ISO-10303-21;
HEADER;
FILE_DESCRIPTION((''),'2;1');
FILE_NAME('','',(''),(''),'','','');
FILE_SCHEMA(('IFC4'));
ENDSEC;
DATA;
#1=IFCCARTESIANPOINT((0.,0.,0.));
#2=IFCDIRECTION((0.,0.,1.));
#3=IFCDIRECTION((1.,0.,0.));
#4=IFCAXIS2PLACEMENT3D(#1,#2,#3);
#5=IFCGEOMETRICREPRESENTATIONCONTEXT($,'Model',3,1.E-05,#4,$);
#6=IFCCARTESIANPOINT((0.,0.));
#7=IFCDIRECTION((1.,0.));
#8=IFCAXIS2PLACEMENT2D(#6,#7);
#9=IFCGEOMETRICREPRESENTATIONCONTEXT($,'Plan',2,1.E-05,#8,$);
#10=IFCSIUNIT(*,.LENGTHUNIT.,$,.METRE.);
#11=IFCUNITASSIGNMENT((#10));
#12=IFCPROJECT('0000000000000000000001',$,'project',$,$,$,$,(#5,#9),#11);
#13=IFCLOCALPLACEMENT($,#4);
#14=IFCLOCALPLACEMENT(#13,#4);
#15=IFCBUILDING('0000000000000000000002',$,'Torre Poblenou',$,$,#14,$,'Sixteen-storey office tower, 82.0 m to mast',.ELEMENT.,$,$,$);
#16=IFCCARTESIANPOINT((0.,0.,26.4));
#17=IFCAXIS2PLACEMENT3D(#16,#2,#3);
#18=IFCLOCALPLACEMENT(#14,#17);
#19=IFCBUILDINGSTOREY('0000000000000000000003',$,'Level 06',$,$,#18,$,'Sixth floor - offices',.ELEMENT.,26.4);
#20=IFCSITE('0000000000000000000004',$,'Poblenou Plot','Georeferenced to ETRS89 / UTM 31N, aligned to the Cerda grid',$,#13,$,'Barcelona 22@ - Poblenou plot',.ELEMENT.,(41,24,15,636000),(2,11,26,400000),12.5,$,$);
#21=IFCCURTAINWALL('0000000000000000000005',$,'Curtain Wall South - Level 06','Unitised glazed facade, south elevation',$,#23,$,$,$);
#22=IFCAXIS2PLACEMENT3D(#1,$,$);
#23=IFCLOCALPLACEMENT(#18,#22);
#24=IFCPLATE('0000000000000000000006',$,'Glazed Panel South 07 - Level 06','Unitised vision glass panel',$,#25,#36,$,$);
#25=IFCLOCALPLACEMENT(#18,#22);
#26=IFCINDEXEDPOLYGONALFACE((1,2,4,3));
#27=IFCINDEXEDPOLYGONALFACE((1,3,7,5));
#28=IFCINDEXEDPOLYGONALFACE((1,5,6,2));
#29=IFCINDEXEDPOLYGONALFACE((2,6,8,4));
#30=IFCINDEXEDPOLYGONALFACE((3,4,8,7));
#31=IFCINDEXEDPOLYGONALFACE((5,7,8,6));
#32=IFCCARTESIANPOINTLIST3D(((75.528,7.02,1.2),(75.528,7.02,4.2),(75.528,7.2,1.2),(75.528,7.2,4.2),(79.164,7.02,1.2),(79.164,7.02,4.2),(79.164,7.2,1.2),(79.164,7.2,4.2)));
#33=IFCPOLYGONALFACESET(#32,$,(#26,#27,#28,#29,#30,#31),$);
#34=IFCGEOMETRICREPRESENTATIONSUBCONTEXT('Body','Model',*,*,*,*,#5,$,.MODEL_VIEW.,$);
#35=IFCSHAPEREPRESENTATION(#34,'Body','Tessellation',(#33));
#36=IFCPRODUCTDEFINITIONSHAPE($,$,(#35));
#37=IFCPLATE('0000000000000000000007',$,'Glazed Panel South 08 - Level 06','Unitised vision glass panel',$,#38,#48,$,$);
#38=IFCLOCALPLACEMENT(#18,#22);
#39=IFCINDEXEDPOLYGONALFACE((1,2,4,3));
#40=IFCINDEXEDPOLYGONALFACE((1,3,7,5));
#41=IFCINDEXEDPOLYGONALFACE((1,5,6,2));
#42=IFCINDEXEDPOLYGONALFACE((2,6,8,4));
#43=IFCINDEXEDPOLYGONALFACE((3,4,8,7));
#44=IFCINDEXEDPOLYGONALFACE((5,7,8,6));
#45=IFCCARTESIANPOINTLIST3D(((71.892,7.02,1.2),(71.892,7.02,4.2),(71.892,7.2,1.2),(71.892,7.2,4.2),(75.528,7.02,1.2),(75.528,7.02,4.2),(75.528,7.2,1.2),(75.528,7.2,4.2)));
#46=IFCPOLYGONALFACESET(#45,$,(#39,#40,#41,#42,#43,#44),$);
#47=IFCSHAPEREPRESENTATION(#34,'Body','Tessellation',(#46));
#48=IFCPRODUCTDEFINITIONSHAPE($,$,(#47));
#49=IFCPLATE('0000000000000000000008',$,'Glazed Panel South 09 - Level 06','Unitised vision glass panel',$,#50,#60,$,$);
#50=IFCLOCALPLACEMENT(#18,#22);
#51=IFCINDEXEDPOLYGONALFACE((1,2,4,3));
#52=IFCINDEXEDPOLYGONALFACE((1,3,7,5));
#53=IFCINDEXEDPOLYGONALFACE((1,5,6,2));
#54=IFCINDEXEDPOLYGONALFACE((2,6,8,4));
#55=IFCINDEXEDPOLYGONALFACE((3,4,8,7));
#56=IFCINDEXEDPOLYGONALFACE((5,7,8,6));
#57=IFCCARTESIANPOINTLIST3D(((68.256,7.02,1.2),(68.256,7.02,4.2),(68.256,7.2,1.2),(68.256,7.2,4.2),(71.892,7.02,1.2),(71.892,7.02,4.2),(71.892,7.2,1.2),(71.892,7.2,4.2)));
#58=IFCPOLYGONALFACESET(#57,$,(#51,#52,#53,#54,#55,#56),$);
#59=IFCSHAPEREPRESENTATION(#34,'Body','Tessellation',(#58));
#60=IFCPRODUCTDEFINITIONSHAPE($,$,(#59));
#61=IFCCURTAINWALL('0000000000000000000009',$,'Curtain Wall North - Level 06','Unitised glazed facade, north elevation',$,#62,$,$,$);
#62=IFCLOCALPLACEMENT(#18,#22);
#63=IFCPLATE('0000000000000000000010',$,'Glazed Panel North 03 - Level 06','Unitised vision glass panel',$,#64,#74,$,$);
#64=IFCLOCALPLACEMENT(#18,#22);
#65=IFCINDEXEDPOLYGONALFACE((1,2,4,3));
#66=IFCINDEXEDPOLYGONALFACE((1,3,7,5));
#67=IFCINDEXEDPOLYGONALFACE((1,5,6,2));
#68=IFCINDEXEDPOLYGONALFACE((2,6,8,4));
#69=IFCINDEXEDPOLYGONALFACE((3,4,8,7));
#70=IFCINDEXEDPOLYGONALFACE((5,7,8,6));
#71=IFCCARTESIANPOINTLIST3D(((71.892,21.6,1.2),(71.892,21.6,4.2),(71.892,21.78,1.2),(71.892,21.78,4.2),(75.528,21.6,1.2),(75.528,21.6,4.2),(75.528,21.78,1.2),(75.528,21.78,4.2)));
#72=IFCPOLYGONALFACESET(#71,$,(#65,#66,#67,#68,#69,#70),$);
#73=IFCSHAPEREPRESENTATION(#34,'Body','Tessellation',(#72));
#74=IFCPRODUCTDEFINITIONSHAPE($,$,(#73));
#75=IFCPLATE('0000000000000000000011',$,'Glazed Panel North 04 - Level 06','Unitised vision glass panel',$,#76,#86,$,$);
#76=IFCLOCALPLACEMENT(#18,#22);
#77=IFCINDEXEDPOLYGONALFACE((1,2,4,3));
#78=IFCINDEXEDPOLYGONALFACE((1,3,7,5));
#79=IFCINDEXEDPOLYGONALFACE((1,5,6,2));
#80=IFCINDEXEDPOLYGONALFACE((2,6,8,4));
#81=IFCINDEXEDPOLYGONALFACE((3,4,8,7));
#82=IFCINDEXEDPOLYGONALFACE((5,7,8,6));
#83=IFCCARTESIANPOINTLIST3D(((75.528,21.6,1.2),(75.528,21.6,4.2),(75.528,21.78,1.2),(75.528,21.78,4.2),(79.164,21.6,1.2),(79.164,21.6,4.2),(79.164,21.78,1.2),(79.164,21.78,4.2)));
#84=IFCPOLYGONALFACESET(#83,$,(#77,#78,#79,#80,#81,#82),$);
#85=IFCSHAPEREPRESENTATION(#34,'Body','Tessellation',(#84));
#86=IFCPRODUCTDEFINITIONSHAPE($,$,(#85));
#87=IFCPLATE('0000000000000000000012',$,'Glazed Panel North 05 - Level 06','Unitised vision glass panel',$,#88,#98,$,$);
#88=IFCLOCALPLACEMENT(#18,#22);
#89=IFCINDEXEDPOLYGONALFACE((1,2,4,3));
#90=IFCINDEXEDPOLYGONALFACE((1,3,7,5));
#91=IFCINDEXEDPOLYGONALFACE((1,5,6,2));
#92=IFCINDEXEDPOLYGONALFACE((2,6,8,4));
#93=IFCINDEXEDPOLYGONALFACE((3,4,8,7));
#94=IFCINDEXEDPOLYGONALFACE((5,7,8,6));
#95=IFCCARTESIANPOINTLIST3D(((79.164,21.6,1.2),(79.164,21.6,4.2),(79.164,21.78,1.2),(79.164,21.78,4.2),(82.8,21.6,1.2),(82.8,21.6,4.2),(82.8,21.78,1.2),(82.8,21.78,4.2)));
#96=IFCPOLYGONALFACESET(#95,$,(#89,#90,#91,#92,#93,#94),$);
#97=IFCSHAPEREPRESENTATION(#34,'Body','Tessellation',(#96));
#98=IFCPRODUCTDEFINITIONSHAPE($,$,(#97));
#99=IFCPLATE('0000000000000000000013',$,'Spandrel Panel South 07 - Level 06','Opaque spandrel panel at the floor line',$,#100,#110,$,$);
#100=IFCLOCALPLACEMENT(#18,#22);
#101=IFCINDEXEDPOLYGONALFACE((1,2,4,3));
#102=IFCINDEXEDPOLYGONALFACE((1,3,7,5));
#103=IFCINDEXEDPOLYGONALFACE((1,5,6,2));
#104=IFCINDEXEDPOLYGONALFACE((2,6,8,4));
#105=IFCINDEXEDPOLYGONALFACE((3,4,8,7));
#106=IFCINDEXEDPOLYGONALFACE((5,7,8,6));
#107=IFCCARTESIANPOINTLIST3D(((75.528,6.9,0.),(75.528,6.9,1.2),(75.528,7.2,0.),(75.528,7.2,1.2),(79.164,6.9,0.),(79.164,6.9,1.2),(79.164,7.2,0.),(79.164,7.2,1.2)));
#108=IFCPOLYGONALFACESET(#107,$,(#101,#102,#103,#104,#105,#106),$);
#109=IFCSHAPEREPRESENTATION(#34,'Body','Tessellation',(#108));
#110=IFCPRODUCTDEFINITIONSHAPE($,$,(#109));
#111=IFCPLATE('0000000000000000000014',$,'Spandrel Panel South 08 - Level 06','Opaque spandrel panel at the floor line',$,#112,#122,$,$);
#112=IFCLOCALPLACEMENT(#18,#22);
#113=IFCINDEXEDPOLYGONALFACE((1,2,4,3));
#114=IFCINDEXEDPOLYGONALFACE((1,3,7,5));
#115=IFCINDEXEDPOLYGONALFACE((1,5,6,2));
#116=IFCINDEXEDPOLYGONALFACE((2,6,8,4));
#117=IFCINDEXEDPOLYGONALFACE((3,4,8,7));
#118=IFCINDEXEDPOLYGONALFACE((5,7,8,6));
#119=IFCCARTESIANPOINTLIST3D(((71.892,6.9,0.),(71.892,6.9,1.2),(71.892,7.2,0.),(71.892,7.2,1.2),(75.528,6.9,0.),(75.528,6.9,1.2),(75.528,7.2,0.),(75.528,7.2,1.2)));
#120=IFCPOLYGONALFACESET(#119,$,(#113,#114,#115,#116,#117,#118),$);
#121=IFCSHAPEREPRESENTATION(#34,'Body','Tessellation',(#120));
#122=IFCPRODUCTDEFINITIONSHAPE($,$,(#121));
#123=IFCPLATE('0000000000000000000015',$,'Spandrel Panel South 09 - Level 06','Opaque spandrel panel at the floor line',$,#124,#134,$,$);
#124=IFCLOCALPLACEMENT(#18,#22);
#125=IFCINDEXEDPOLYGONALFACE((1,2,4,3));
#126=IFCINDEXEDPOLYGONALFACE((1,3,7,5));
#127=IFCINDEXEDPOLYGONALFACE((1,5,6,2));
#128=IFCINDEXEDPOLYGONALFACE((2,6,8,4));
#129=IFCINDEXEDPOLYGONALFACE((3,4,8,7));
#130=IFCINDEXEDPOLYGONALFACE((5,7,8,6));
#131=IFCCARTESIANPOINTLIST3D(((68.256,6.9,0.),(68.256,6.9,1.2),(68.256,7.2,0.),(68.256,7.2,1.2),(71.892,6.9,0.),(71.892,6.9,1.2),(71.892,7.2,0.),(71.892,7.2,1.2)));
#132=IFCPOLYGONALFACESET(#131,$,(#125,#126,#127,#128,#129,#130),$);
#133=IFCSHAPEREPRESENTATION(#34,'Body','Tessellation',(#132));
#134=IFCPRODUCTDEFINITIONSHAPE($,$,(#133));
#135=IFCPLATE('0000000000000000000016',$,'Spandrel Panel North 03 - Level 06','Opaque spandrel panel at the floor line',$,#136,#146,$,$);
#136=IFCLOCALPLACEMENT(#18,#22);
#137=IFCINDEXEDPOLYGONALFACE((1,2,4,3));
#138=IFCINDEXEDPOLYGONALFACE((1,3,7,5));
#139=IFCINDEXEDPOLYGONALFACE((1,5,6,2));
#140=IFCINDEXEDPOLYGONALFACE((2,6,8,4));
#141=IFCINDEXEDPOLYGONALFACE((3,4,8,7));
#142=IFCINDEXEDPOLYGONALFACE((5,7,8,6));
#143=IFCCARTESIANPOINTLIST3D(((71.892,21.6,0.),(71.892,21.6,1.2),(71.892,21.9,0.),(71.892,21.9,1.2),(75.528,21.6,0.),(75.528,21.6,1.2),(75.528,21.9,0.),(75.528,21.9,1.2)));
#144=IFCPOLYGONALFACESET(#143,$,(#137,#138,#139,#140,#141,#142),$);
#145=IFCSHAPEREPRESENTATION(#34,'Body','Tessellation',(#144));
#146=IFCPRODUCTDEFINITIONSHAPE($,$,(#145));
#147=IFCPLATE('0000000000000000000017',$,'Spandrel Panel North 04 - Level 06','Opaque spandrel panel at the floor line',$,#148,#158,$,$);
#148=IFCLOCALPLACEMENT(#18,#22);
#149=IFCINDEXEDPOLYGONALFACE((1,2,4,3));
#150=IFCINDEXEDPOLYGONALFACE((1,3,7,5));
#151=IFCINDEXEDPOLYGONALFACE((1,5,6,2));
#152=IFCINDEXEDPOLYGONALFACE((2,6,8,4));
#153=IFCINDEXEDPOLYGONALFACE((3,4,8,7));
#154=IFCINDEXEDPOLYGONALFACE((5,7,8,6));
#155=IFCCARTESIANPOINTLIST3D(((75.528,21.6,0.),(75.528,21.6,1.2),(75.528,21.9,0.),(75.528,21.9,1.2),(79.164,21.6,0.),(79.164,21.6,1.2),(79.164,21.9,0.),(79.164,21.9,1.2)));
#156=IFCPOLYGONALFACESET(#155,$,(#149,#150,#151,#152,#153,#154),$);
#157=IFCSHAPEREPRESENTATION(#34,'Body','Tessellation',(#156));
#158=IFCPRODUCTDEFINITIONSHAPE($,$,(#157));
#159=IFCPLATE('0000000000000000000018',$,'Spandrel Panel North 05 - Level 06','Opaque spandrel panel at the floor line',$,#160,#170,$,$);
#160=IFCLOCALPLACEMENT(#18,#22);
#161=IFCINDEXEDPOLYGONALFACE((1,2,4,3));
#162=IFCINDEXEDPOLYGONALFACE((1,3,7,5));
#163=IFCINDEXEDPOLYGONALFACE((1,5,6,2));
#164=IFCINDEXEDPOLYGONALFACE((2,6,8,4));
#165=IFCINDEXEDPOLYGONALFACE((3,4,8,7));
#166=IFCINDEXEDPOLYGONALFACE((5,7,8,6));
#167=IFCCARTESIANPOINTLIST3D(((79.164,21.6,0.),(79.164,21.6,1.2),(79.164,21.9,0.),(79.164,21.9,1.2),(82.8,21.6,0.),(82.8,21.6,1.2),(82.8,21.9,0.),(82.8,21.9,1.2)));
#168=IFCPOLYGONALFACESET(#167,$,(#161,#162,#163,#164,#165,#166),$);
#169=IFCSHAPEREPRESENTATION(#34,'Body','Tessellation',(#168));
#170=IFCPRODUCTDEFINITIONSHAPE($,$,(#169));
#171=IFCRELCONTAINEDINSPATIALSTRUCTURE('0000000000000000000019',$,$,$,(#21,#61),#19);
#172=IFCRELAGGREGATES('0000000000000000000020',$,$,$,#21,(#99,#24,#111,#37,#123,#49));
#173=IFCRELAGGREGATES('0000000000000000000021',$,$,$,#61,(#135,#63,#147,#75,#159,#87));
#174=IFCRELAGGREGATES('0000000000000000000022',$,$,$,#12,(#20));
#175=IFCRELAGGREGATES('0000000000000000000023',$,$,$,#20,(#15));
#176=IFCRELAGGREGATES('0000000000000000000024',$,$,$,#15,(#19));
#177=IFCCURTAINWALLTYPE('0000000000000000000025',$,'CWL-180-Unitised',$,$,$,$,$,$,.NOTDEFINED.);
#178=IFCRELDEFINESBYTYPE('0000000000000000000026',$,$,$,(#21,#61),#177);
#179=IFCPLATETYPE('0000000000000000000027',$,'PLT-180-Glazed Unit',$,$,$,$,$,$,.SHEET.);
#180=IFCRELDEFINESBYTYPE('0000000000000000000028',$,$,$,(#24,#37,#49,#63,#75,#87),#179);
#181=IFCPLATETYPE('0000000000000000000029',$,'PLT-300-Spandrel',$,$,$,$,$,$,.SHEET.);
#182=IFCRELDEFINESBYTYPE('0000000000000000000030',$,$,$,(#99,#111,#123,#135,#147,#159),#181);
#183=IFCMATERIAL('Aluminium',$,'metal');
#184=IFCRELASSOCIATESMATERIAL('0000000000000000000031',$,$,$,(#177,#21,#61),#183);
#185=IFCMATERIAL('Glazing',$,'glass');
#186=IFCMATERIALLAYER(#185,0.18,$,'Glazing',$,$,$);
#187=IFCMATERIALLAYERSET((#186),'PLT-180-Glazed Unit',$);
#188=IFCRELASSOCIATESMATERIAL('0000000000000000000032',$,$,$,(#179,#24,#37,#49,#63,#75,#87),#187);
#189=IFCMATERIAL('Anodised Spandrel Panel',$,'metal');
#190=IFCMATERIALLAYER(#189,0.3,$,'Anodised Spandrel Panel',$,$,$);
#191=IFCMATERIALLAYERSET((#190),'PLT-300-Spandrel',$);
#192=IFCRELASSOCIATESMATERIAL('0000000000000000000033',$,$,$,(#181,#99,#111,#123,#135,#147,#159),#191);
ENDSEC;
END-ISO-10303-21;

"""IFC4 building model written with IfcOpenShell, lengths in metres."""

from ifc_helpers import new_model, si_unit, frame, origin_with_axes, origin_2d_with_axis, place, context, subcontext, project, spatial, line, indexed_curve, outline, extrude, material, layer, layer_set, layer_usage, type_object, element, aggregate, save


model = new_model("IFC4")

# Units and contexts
model_context = context("Model", 3, precision=1e-05, world=origin_with_axes())
plan_context = context("Plan", 2, precision=1e-05, world=origin_2d_with_axis())
body_context = subcontext(model_context, "Body", "Model", "MODEL_VIEW")
ifc_project = project(units=[si_unit("LENGTHUNIT", "METRE")], contexts=[model_context, plan_context])

# Site, building, storey
site_placement = place(None, origin_with_axes())
site = spatial("IfcSite", under=ifc_project, at=site_placement, Name="Poblenou Plot", Description="Georeferenced to ETRS89 / UTM 31N, aligned to the Cerda grid", LongName="Barcelona 22@ - Poblenou plot", CompositionType="ELEMENT", RefLatitude=(41, 24, 15, 636000), RefLongitude=(2, 11, 26, 400000), RefElevation=12.5)
building_placement = place(site_placement, origin_with_axes())
building = spatial("IfcBuilding", under=site, at=building_placement, Name="Torre Poblenou", LongName="Sixteen-storey office tower, 82.0 m to mast", CompositionType="ELEMENT")
storey_placement = place(building_placement, frame((0.0, 0.0, 26.4), z_axis=(0.0, 0.0, 1.0), x_axis=(1.0, 0.0, 0.0)))
storey = spatial("IfcBuildingStorey", under=building, at=storey_placement, Name="Level 06", LongName="Sixth floor - offices", CompositionType="ELEMENT", Elevation=26.4)

# Curtain walls, plates
ifc_material_1 = material(Name="Aluminium", Category="metal")
curtain_wall_type = type_object("IfcCurtainWallType", Name="CWL-180-Unitised", PredefinedType="NOTDEFINED", material=ifc_material_1)
curtain_wall_1_placement = place(storey_placement, frame((100.98, 7.2, 0.0), z_axis=(0.0, 0.0, 1.0), x_axis=(-1.0, 0.0, 0.0)))
curtain_wall_1 = element("IfcCurtainWall", 1, at=curtain_wall_1_placement, inside=storey, type_object=curtain_wall_type, material=ifc_material_1, Name="Curtain Wall South - Level 06", Description="Unitised glazed facade, south elevation")
ifc_material_2 = material(Name="Glazing", Category="glass")
ifc_layer_1 = layer(ifc_material_2, 0.18, Name="Glazing")
ifc_layer_set_1 = layer_set([ifc_layer_1], Name="PLT-180-Glazed Unit")
ifc_layer_usage_1 = layer_usage(ifc_layer_set_1, "AXIS2", "POSITIVE", 0.0)
plate_type_1 = type_object("IfcPlateType", Name="PLT-180-Glazed Unit", PredefinedType="SHEET", material=ifc_layer_set_1)
plate_1_placement = place(curtain_wall_1_placement, frame((21.816, 0.0, 1.2), z_axis=(0.0, 0.0, 1.0), x_axis=(1.0, 0.0, 0.0)))
plate_1 = element("IfcPlate", 2, at=plate_1_placement, type_object=plate_type_1, material=ifc_layer_usage_1, Name="Glazed Panel South 07 - Level 06", Description="Unitised vision glass panel", context=body_context, shape_type="SweptSolid", body=[
    extrude(outline(indexed_curve([(0.0, 0.0), (3.636, 0.0), (3.636, 0.18), (0.0, 0.18)], segments=[line(1, 2, 3, 4, 1)])), origin_with_axes(), (0.0, 0.0, 1.0), 3.0),
])
ifc_layer_usage_2 = layer_usage(ifc_layer_set_1, "AXIS2", "POSITIVE", 0.0)
plate_2_placement = place(curtain_wall_1_placement, frame((25.452, 0.0, 1.2), z_axis=(0.0, 0.0, 1.0), x_axis=(1.0, 0.0, 0.0)))
plate_2 = element("IfcPlate", 3, at=plate_2_placement, type_object=plate_type_1, material=ifc_layer_usage_2, Name="Glazed Panel South 08 - Level 06", Description="Unitised vision glass panel", context=body_context, shape_type="SweptSolid", body=[
    extrude(outline(indexed_curve([(0.0, 0.0), (3.636, 0.0), (3.636, 0.18), (0.0, 0.18)], segments=[line(1, 2, 3, 4, 1)])), origin_with_axes(), (0.0, 0.0, 1.0), 3.0),
])
ifc_layer_usage_3 = layer_usage(ifc_layer_set_1, "AXIS2", "POSITIVE", 0.0)
plate_3_placement = place(curtain_wall_1_placement, frame((29.088, 0.0, 1.2), z_axis=(0.0, 0.0, 1.0), x_axis=(1.0, 0.0, 0.0)))
plate_3 = element("IfcPlate", 4, at=plate_3_placement, type_object=plate_type_1, material=ifc_layer_usage_3, Name="Glazed Panel South 09 - Level 06", Description="Unitised vision glass panel", context=body_context, shape_type="SweptSolid", body=[
    extrude(outline(indexed_curve([(0.0, 0.0), (3.636, 0.0), (3.636, 0.18), (0.0, 0.18)], segments=[line(1, 2, 3, 4, 1)])), origin_with_axes(), (0.0, 0.0, 1.0), 3.0),
])
curtain_wall_2_placement = place(storey_placement, frame((64.62, 21.6, 0.0), z_axis=(0.0, 0.0, 1.0), x_axis=(1.0, 0.0, 0.0)))
curtain_wall_2 = element("IfcCurtainWall", 5, at=curtain_wall_2_placement, inside=storey, type_object=curtain_wall_type, material=ifc_material_1, Name="Curtain Wall North - Level 06", Description="Unitised glazed facade, north elevation")
ifc_layer_usage_4 = layer_usage(ifc_layer_set_1, "AXIS2", "POSITIVE", 0.0)
plate_4_placement = place(curtain_wall_2_placement, frame((7.272, 0.0, 1.2), z_axis=(0.0, 0.0, 1.0), x_axis=(1.0, 0.0, 0.0)))
plate_4 = element("IfcPlate", 6, at=plate_4_placement, type_object=plate_type_1, material=ifc_layer_usage_4, Name="Glazed Panel North 03 - Level 06", Description="Unitised vision glass panel", context=body_context, shape_type="SweptSolid", body=[
    extrude(outline(indexed_curve([(0.0, 0.0), (3.636, 0.0), (3.636, 0.18), (0.0, 0.18)], segments=[line(1, 2, 3, 4, 1)])), origin_with_axes(), (0.0, 0.0, 1.0), 3.0),
])
ifc_layer_usage_5 = layer_usage(ifc_layer_set_1, "AXIS2", "POSITIVE", 0.0)
plate_5_placement = place(curtain_wall_2_placement, frame((10.908, 0.0, 1.2), z_axis=(0.0, 0.0, 1.0), x_axis=(1.0, 0.0, 0.0)))
plate_5 = element("IfcPlate", 7, at=plate_5_placement, type_object=plate_type_1, material=ifc_layer_usage_5, Name="Glazed Panel North 04 - Level 06", Description="Unitised vision glass panel", context=body_context, shape_type="SweptSolid", body=[
    extrude(outline(indexed_curve([(0.0, 0.0), (3.636, 0.0), (3.636, 0.18), (0.0, 0.18)], segments=[line(1, 2, 3, 4, 1)])), origin_with_axes(), (0.0, 0.0, 1.0), 3.0),
])
ifc_layer_usage_6 = layer_usage(ifc_layer_set_1, "AXIS2", "POSITIVE", 0.0)
plate_6_placement = place(curtain_wall_2_placement, frame((14.544, 0.0, 1.2), z_axis=(0.0, 0.0, 1.0), x_axis=(1.0, 0.0, 0.0)))
plate_6 = element("IfcPlate", 8, at=plate_6_placement, type_object=plate_type_1, material=ifc_layer_usage_6, Name="Glazed Panel North 05 - Level 06", Description="Unitised vision glass panel", context=body_context, shape_type="SweptSolid", body=[
    extrude(outline(indexed_curve([(0.0, 0.0), (3.636, 0.0), (3.636, 0.18), (0.0, 0.18)], segments=[line(1, 2, 3, 4, 1)])), origin_with_axes(), (0.0, 0.0, 1.0), 3.0),
])

# Plates
ifc_material_3 = material(Name="Anodised Spandrel Panel", Category="metal")
ifc_layer_2 = layer(ifc_material_3, 0.3, Name="Anodised Spandrel Panel")
ifc_layer_set_2 = layer_set([ifc_layer_2], Name="PLT-300-Spandrel")
ifc_layer_usage_7 = layer_usage(ifc_layer_set_2, "AXIS2", "POSITIVE", 0.0)
plate_type_2 = type_object("IfcPlateType", Name="PLT-300-Spandrel", PredefinedType="SHEET", material=ifc_layer_set_2)
plate_7_placement = place(curtain_wall_1_placement, frame((21.816, 0.0, 0.0), z_axis=(0.0, 0.0, 1.0), x_axis=(1.0, 0.0, 0.0)))
plate_7 = element("IfcPlate", 9, at=plate_7_placement, type_object=plate_type_2, material=ifc_layer_usage_7, Name="Spandrel Panel South 07 - Level 06", Description="Opaque spandrel panel at the floor line", context=body_context, shape_type="SweptSolid", body=[
    extrude(outline(indexed_curve([(0.0, 0.0), (3.636, 0.0), (3.636, 0.3), (0.0, 0.3)], segments=[line(1, 2, 3, 4, 1)])), origin_with_axes(), (0.0, 0.0, 1.0), 1.2),
])
ifc_layer_usage_8 = layer_usage(ifc_layer_set_2, "AXIS2", "POSITIVE", 0.0)
plate_8_placement = place(curtain_wall_1_placement, frame((25.452, 0.0, 0.0), z_axis=(0.0, 0.0, 1.0), x_axis=(1.0, 0.0, 0.0)))
plate_8 = element("IfcPlate", 10, at=plate_8_placement, type_object=plate_type_2, material=ifc_layer_usage_8, Name="Spandrel Panel South 08 - Level 06", Description="Opaque spandrel panel at the floor line", context=body_context, shape_type="SweptSolid", body=[
    extrude(outline(indexed_curve([(0.0, 0.0), (3.636, 0.0), (3.636, 0.3), (0.0, 0.3)], segments=[line(1, 2, 3, 4, 1)])), origin_with_axes(), (0.0, 0.0, 1.0), 1.2),
])
ifc_layer_usage_9 = layer_usage(ifc_layer_set_2, "AXIS2", "POSITIVE", 0.0)
plate_9_placement = place(curtain_wall_1_placement, frame((29.088, 0.0, 0.0), z_axis=(0.0, 0.0, 1.0), x_axis=(1.0, 0.0, 0.0)))
plate_9 = element("IfcPlate", 11, at=plate_9_placement, type_object=plate_type_2, material=ifc_layer_usage_9, Name="Spandrel Panel South 09 - Level 06", Description="Opaque spandrel panel at the floor line", context=body_context, shape_type="SweptSolid", body=[
    extrude(outline(indexed_curve([(0.0, 0.0), (3.636, 0.0), (3.636, 0.3), (0.0, 0.3)], segments=[line(1, 2, 3, 4, 1)])), origin_with_axes(), (0.0, 0.0, 1.0), 1.2),
])
aggregate(curtain_wall_1, [plate_7, plate_1, plate_8, plate_2, plate_9, plate_3])
ifc_layer_usage_10 = layer_usage(ifc_layer_set_2, "AXIS2", "POSITIVE", 0.0)
plate_10_placement = place(curtain_wall_2_placement, frame((7.272, 0.0, 0.0), z_axis=(0.0, 0.0, 1.0), x_axis=(1.0, 0.0, 0.0)))
plate_10 = element("IfcPlate", 12, at=plate_10_placement, type_object=plate_type_2, material=ifc_layer_usage_10, Name="Spandrel Panel North 03 - Level 06", Description="Opaque spandrel panel at the floor line", context=body_context, shape_type="SweptSolid", body=[
    extrude(outline(indexed_curve([(0.0, 0.0), (3.636, 0.0), (3.636, 0.3), (0.0, 0.3)], segments=[line(1, 2, 3, 4, 1)])), origin_with_axes(), (0.0, 0.0, 1.0), 1.2),
])
ifc_layer_usage_11 = layer_usage(ifc_layer_set_2, "AXIS2", "POSITIVE", 0.0)
plate_11_placement = place(curtain_wall_2_placement, frame((10.908, 0.0, 0.0), z_axis=(0.0, 0.0, 1.0), x_axis=(1.0, 0.0, 0.0)))
plate_11 = element("IfcPlate", 13, at=plate_11_placement, type_object=plate_type_2, material=ifc_layer_usage_11, Name="Spandrel Panel North 04 - Level 06", Description="Opaque spandrel panel at the floor line", context=body_context, shape_type="SweptSolid", body=[
    extrude(outline(indexed_curve([(0.0, 0.0), (3.636, 0.0), (3.636, 0.3), (0.0, 0.3)], segments=[line(1, 2, 3, 4, 1)])), origin_with_axes(), (0.0, 0.0, 1.0), 1.2),
])
ifc_layer_usage_12 = layer_usage(ifc_layer_set_2, "AXIS2", "POSITIVE", 0.0)
plate_12_placement = place(curtain_wall_2_placement, frame((14.544, 0.0, 0.0), z_axis=(0.0, 0.0, 1.0), x_axis=(1.0, 0.0, 0.0)))
plate_12 = element("IfcPlate", 14, at=plate_12_placement, type_object=plate_type_2, material=ifc_layer_usage_12, Name="Spandrel Panel North 05 - Level 06", Description="Opaque spandrel panel at the floor line", context=body_context, shape_type="SweptSolid", body=[
    extrude(outline(indexed_curve([(0.0, 0.0), (3.636, 0.0), (3.636, 0.3), (0.0, 0.3)], segments=[line(1, 2, 3, 4, 1)])), origin_with_axes(), (0.0, 0.0, 1.0), 1.2),
])
aggregate(curtain_wall_2, [plate_10, plate_4, plate_11, plate_5, plate_12, plate_6])

save(model, "model.ifc")
